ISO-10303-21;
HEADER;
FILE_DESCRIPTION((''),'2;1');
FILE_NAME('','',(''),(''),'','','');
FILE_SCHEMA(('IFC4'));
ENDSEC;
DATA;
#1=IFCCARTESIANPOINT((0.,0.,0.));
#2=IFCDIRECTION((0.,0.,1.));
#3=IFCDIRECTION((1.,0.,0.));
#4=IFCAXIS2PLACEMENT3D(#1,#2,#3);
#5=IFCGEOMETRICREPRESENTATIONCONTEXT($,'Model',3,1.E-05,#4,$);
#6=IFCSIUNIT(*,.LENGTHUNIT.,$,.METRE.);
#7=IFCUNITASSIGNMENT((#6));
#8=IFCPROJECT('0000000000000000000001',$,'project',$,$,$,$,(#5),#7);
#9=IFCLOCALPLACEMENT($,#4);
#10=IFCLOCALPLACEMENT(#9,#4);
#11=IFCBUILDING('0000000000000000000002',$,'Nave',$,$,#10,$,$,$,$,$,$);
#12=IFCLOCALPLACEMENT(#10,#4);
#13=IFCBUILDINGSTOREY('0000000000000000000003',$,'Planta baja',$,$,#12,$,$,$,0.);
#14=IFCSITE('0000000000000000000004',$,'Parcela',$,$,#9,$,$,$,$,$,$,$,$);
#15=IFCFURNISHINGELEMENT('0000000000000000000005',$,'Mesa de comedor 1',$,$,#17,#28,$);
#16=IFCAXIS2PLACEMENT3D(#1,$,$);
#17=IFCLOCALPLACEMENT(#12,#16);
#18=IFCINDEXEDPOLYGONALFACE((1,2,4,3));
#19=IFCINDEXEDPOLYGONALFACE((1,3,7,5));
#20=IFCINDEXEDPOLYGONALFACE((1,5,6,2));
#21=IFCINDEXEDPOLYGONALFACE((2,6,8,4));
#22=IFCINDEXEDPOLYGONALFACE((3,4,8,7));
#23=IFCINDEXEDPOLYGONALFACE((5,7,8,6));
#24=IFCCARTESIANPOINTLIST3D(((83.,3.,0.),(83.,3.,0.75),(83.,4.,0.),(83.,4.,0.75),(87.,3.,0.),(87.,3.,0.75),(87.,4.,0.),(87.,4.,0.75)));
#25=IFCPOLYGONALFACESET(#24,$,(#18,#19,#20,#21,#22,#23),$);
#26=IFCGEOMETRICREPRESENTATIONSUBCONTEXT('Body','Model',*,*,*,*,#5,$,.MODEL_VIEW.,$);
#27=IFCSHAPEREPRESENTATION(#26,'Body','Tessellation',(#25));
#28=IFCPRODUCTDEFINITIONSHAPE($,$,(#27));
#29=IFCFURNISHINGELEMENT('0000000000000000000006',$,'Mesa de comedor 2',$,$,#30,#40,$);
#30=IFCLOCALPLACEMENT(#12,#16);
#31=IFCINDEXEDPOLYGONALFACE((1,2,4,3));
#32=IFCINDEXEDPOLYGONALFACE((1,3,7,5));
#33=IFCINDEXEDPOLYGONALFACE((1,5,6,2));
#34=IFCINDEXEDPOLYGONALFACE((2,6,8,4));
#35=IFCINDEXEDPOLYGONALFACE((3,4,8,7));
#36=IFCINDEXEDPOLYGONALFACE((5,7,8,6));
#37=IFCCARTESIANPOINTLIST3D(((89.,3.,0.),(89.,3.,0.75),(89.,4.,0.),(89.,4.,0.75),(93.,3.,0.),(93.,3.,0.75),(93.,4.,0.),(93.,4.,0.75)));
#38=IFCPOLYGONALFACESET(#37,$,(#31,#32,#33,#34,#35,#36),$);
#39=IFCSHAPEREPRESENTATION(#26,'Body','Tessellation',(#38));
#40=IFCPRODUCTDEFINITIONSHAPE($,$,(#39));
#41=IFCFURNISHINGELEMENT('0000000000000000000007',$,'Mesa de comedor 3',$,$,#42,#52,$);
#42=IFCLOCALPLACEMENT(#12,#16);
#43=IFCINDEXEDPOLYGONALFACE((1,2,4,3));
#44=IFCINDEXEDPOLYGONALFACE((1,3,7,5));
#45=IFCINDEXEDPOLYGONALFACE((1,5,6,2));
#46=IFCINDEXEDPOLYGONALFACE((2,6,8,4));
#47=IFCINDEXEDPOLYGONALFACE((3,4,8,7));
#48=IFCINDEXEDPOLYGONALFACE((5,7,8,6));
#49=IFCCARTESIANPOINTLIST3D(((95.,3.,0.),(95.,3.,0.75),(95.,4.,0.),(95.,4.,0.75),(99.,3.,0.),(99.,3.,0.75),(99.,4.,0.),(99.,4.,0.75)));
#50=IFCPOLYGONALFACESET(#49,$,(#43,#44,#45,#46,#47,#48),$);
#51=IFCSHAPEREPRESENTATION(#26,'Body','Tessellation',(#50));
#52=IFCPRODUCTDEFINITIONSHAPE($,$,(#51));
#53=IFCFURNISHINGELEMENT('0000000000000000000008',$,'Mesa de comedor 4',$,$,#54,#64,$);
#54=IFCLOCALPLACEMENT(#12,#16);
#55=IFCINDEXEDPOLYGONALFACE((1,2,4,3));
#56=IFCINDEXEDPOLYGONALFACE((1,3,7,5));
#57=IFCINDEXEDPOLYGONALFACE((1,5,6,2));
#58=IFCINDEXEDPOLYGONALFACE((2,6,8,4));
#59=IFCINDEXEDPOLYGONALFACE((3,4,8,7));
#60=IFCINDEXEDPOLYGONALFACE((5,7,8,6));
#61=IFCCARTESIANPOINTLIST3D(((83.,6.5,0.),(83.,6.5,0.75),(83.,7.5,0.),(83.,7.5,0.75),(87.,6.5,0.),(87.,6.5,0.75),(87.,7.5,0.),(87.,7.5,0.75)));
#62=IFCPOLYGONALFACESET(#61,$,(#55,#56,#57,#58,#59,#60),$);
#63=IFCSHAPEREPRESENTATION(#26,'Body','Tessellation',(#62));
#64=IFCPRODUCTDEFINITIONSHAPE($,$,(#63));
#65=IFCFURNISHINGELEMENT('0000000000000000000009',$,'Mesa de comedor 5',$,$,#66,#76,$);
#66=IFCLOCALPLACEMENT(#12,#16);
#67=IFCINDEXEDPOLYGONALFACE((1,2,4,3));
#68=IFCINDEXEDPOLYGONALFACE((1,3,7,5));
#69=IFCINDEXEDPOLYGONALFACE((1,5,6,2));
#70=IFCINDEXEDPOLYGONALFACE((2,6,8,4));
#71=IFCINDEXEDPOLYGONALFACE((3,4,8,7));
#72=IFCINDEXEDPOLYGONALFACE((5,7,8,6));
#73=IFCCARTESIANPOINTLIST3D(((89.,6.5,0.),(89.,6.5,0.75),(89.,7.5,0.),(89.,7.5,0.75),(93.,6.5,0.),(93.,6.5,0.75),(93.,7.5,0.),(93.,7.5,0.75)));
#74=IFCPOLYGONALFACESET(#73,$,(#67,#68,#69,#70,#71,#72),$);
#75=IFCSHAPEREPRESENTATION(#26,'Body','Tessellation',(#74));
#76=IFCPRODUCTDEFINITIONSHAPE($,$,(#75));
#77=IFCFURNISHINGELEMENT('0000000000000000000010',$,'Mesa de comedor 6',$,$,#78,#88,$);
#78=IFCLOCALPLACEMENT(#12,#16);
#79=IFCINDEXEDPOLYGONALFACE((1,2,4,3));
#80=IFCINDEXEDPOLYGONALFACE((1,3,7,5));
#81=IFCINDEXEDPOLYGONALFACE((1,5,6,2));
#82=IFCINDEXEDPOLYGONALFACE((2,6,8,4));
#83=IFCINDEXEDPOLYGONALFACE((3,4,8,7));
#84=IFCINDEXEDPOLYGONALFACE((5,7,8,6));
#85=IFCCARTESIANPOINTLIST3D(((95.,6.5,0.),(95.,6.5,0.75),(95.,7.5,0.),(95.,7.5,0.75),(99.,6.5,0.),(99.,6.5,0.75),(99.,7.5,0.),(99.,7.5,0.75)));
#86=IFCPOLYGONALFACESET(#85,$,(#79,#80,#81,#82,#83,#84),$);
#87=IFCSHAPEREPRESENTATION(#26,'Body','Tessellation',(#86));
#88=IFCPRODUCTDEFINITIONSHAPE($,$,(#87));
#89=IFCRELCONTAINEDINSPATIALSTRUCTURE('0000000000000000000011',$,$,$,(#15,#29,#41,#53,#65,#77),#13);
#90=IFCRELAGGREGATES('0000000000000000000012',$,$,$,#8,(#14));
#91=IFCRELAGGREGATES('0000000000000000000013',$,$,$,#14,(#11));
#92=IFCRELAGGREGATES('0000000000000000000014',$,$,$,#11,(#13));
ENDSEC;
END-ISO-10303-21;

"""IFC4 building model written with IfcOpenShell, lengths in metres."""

from ifc_helpers import new_model, si_unit, frame, origin_with_axes, place, context, subcontext, project, spatial, indexed_curve, outline, extrude, element, save


model = new_model("IFC4")

# Units and contexts
model_context = context("Model", 3, precision=1e-05, world=origin_with_axes())
body_context = subcontext(model_context, "Body", "Model", "MODEL_VIEW")
ifc_project = project(units=[si_unit("LENGTHUNIT", "METRE")], contexts=[model_context])

# Site, building, storey
site_placement = place(None, origin_with_axes())
site = spatial("IfcSite", under=ifc_project, at=site_placement, Name="Parcela")
building_placement = place(site_placement, origin_with_axes())
building = spatial("IfcBuilding", under=site, at=building_placement, Name="Nave")
storey_placement = place(building_placement, origin_with_axes())
storey = spatial("IfcBuildingStorey", under=building, at=storey_placement, Name="Planta baja", Elevation=0.0)

# Furnishing elements
for number, where, z_axis, x_axis, name in (
    (1, (83.0, 3.0, 0.0), (0.0, 0.0, 1.0), (1.0, 0.0, 0.0), "Mesa de comedor 1"),
    (2, (89.0, 3.0, 0.0), (0.0, 0.0, 1.0), (1.0, 0.0, 0.0), "Mesa de comedor 2"),
    (3, (95.0, 3.0, 0.0), (0.0, 0.0, 1.0), (1.0, 0.0, 0.0), "Mesa de comedor 3"),
    (4, (83.0, 6.5, 0.0), (0.0, 0.0, 1.0), (1.0, 0.0, 0.0), "Mesa de comedor 4"),
    (5, (89.0, 6.5, 0.0), (0.0, 0.0, 1.0), (1.0, 0.0, 0.0), "Mesa de comedor 5"),
    (6, (95.0, 6.5, 0.0), (0.0, 0.0, 1.0), (1.0, 0.0, 0.0), "Mesa de comedor 6"),
):
    element("IfcFurnishingElement", number, at=place(storey_placement, frame(where, z_axis=z_axis, x_axis=x_axis)), inside=storey, Name=name, context=body_context, shape_type="SweptSolid", body=[
        extrude(outline(indexed_curve([(0.0, 0.0), (0.0, 1.0), (4.0, 1.0), (4.0, 0.0), (0.0, 0.0)], self_intersect=False)), origin_with_axes(), (0.0, 0.0, 1.0), 0.75),
    ])

save(model, "model.ifc")
